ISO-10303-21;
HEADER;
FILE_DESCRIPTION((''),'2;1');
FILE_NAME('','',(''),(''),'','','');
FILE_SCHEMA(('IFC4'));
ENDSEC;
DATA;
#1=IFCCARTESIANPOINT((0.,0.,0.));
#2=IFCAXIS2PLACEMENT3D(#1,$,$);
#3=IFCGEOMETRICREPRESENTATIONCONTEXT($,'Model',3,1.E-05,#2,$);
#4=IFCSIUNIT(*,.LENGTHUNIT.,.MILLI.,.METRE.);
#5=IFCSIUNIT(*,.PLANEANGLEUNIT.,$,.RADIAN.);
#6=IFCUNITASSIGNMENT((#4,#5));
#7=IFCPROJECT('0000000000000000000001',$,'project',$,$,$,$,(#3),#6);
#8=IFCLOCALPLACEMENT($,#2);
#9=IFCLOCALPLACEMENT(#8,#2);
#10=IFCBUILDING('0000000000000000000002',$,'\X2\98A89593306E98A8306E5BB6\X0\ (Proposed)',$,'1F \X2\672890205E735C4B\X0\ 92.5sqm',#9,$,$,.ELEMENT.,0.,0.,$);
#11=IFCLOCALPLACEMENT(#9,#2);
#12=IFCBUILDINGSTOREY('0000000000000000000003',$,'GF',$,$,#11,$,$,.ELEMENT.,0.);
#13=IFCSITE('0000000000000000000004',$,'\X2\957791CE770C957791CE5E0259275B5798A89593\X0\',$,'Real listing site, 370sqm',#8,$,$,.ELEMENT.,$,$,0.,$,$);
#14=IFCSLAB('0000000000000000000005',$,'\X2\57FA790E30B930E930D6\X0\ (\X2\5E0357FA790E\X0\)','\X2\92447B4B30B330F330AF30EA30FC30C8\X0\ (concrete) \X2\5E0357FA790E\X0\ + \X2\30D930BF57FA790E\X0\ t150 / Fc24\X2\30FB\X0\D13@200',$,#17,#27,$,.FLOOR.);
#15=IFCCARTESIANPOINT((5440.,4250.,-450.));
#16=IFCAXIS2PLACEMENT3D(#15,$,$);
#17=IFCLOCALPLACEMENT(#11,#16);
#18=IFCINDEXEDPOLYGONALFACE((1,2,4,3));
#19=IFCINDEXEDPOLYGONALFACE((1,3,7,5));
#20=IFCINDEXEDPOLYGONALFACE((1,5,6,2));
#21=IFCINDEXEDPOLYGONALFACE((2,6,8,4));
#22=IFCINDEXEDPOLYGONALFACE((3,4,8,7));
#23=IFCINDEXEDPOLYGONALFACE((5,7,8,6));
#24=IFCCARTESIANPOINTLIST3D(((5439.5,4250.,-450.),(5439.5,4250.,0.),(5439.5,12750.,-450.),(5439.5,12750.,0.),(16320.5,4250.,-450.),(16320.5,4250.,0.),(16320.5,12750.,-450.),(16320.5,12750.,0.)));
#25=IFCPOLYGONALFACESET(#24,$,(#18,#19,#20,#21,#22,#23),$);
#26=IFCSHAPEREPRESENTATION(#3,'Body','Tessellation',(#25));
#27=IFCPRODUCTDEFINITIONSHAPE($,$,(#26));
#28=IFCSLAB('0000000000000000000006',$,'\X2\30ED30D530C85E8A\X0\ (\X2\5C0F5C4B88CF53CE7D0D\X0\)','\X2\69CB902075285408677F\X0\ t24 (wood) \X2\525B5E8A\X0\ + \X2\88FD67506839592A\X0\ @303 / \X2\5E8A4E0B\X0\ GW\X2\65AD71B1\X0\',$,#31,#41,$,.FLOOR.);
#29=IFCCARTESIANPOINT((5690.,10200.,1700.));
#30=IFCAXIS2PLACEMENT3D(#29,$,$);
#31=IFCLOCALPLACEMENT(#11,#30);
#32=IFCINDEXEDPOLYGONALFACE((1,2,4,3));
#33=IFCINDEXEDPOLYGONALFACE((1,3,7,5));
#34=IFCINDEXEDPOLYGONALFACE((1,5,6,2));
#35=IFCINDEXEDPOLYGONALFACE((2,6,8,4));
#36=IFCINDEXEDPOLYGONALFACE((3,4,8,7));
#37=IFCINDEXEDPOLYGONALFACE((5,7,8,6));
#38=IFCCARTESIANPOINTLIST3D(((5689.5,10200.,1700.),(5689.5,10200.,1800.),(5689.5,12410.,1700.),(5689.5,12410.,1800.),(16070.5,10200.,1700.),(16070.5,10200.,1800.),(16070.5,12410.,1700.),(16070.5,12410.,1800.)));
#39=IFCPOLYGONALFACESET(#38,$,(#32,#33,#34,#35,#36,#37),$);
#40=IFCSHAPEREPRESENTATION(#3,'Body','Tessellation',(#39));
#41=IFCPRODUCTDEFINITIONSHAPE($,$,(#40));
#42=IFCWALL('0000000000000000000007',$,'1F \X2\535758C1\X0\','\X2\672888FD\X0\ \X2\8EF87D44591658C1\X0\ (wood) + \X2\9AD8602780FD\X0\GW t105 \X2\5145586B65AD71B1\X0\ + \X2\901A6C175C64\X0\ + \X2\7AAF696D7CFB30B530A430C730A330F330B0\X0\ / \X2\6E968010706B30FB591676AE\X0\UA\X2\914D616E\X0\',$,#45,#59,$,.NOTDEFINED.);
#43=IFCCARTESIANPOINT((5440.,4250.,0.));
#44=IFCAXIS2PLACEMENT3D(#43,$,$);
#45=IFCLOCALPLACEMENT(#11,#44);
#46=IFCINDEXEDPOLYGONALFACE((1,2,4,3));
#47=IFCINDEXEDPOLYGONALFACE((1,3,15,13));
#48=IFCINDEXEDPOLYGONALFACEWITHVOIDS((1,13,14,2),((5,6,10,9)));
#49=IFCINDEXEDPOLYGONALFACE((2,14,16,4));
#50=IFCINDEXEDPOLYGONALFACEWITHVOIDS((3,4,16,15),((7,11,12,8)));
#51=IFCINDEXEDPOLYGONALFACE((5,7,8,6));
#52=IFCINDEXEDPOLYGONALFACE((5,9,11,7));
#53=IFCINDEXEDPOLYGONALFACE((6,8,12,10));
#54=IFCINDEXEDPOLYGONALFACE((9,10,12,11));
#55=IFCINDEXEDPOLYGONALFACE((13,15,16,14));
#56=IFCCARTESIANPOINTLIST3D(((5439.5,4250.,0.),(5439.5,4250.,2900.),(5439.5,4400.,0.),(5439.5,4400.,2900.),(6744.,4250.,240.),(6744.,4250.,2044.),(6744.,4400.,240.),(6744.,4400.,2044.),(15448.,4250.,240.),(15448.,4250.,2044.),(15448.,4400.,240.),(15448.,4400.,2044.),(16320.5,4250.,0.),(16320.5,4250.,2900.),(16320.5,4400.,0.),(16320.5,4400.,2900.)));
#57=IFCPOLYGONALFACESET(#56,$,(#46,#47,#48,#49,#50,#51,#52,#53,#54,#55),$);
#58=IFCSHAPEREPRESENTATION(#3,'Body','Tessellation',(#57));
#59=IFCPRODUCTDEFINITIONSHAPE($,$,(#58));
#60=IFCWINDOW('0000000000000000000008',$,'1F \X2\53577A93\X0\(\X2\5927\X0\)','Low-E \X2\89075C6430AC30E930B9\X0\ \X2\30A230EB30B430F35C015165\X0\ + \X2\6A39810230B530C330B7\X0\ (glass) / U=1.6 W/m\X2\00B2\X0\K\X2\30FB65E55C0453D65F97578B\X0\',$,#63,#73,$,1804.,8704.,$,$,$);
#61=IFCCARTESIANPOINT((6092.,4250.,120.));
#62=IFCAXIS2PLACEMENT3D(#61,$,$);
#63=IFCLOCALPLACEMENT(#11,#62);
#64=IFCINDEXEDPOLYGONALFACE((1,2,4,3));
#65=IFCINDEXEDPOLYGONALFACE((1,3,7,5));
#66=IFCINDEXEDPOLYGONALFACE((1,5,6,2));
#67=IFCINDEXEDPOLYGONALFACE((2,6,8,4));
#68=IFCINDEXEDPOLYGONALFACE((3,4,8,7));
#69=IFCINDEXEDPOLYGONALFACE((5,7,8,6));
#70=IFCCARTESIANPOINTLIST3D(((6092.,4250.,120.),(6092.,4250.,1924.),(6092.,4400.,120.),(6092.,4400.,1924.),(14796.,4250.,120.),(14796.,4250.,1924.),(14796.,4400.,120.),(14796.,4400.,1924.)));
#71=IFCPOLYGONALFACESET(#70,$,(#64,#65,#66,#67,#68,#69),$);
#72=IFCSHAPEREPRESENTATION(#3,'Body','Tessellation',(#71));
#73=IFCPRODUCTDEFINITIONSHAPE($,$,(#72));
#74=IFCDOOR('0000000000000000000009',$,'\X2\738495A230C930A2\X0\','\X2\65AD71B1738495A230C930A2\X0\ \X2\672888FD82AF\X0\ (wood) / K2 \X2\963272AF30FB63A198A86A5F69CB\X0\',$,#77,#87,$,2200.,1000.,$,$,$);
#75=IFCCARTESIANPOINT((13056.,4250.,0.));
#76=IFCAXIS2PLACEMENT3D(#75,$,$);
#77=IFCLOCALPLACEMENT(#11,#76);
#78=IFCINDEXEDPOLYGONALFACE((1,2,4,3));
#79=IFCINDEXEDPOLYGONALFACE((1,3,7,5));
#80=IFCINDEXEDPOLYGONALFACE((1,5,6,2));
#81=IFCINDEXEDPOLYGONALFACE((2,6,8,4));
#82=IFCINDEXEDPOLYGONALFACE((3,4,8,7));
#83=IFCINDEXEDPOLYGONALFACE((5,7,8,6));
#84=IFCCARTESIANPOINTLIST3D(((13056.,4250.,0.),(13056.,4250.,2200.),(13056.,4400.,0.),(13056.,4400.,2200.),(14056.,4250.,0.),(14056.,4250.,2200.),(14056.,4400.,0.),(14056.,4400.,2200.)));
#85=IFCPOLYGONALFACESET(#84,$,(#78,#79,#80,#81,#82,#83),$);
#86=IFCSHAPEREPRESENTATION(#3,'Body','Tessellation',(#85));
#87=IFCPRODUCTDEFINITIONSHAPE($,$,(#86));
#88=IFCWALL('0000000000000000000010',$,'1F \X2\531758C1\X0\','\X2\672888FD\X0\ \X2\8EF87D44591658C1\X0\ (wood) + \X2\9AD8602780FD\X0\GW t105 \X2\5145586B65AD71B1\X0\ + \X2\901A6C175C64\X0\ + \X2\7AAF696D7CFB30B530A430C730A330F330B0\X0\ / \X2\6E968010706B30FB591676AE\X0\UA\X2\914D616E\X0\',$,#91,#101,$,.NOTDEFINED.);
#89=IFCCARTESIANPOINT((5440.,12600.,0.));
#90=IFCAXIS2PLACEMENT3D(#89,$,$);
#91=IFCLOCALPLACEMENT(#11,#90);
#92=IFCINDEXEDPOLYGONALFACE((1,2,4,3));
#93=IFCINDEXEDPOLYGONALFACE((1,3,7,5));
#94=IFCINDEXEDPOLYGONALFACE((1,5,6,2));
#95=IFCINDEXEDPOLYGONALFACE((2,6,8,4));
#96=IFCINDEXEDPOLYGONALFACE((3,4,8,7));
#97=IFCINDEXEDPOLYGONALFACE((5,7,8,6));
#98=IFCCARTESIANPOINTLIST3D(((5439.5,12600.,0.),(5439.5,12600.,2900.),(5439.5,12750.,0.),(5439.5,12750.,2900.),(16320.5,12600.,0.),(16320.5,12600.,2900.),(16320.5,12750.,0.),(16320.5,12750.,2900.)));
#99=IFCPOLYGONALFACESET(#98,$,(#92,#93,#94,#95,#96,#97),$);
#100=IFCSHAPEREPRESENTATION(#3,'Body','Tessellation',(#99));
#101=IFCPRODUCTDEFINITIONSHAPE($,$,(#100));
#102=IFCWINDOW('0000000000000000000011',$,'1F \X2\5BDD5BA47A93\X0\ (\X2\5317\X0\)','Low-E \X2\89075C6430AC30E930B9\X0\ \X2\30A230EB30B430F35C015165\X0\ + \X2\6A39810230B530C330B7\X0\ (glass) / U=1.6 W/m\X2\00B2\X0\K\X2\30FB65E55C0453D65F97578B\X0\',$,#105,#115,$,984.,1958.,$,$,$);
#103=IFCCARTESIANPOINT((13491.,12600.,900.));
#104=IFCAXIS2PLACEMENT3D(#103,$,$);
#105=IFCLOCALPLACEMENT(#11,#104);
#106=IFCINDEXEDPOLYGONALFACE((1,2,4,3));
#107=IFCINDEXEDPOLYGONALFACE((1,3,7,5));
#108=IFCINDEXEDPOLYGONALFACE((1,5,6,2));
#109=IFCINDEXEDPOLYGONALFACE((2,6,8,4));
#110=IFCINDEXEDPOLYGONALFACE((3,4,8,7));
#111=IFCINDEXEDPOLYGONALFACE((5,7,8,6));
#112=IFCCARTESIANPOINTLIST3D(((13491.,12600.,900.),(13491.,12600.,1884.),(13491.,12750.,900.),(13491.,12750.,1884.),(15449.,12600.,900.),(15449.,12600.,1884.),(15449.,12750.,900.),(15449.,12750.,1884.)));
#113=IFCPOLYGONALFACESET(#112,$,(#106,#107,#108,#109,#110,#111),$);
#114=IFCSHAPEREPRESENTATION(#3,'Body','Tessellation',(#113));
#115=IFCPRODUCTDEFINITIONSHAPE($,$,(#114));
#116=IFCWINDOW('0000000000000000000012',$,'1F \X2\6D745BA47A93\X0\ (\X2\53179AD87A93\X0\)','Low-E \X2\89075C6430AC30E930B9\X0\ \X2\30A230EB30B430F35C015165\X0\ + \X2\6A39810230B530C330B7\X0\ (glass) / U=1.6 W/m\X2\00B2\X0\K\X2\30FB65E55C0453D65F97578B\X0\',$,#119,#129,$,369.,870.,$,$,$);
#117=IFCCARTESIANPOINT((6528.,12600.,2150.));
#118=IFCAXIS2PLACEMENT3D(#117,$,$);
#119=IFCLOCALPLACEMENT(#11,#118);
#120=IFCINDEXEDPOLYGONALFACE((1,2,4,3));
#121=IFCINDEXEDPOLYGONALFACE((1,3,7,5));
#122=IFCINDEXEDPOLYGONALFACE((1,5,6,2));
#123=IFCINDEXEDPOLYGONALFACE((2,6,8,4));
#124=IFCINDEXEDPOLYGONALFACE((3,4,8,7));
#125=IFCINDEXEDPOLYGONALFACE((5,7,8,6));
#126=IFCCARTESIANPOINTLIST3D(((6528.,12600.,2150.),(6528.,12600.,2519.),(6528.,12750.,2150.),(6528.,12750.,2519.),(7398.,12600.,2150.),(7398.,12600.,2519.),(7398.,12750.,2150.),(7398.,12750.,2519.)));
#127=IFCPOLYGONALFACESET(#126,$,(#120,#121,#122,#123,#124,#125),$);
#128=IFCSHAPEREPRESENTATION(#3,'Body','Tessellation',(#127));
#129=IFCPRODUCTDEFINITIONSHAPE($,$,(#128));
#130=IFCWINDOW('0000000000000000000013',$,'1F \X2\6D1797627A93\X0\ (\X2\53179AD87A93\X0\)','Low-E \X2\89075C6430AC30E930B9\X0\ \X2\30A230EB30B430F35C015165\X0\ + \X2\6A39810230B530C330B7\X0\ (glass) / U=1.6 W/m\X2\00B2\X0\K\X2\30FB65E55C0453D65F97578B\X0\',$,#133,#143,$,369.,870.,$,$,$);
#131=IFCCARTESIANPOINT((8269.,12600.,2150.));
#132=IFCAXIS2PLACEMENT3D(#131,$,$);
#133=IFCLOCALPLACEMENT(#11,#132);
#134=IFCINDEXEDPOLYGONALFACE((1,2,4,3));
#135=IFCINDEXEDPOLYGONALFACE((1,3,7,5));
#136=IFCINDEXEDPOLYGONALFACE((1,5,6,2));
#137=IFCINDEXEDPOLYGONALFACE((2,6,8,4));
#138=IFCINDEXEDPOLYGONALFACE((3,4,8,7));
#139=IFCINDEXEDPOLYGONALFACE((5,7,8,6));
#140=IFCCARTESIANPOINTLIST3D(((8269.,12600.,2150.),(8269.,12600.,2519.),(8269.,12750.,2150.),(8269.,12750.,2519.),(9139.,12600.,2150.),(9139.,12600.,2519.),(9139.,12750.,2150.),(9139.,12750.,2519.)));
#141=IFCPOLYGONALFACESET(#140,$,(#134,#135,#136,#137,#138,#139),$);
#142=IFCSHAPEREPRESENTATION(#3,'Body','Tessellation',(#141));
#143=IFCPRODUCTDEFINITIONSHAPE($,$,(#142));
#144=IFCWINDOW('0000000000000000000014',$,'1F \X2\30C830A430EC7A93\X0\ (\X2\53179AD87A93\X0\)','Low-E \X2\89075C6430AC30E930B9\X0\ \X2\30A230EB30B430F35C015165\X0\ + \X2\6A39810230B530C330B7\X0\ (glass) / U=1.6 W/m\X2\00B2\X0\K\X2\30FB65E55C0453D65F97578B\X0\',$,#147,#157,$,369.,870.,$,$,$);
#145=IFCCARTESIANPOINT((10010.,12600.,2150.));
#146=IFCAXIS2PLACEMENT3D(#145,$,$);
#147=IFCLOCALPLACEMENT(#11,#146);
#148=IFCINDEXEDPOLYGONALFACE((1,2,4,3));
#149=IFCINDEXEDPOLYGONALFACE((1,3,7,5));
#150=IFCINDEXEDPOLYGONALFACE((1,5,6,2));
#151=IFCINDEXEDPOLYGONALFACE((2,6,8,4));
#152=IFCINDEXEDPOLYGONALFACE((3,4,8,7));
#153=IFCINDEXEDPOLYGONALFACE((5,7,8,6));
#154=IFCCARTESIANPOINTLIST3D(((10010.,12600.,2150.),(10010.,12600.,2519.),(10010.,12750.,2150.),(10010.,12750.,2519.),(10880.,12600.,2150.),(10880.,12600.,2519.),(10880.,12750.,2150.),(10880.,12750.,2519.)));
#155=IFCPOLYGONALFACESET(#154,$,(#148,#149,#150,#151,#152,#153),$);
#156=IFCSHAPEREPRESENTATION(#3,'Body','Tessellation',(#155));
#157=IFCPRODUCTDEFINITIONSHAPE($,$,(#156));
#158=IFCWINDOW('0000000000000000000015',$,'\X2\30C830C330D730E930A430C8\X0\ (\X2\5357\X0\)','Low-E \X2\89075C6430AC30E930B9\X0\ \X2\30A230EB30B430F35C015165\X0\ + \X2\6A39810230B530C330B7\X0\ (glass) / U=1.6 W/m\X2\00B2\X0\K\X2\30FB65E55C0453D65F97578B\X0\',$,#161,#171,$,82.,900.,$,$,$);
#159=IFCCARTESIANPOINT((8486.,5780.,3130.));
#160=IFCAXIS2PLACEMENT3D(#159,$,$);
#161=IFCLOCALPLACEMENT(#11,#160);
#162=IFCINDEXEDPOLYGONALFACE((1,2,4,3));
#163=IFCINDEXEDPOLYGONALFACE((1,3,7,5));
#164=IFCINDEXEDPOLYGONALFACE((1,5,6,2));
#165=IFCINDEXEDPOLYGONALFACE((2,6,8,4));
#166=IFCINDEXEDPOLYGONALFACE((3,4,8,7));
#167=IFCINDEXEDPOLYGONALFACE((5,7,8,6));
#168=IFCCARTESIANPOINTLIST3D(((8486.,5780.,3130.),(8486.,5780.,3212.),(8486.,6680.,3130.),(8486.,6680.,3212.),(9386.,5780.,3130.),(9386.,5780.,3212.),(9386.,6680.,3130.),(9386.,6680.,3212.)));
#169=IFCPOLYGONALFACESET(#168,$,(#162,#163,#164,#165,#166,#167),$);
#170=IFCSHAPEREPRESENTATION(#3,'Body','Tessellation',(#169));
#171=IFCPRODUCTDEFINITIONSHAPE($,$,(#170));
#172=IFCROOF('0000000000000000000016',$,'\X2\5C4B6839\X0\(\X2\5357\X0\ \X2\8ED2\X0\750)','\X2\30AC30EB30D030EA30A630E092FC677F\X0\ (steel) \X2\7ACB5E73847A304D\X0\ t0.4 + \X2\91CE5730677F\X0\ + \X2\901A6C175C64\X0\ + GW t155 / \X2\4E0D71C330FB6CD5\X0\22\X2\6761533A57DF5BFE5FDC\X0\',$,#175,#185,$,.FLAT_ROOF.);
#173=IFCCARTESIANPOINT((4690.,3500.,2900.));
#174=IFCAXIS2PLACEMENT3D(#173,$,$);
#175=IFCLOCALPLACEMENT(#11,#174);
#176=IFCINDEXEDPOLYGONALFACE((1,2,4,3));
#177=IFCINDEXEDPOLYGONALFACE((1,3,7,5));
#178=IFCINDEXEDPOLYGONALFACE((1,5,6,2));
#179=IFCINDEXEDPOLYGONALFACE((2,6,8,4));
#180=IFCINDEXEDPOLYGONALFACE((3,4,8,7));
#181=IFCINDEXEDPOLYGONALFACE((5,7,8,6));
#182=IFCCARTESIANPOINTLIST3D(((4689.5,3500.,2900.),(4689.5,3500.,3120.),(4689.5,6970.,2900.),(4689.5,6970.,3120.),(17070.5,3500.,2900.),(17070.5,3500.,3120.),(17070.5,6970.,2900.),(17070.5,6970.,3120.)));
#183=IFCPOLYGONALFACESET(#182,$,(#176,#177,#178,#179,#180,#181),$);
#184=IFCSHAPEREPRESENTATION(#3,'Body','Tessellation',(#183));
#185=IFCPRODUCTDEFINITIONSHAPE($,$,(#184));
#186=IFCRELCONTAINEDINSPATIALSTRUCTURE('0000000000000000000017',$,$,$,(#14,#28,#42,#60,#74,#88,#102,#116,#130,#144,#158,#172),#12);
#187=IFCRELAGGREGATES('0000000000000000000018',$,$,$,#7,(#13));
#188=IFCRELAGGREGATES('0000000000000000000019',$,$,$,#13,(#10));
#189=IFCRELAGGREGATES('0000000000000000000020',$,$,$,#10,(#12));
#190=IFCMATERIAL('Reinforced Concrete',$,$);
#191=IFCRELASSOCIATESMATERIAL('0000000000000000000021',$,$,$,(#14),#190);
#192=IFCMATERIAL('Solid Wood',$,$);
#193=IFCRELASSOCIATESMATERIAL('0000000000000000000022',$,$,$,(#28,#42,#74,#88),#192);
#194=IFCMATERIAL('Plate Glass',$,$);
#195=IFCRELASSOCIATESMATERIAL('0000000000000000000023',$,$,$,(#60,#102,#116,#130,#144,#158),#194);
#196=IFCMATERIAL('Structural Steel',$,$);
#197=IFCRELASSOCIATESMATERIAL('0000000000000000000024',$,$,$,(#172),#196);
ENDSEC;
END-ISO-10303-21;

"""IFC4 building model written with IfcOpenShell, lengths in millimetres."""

from ifc_helpers import new_model, si_unit, frame, frame_2d, origin, place, context, project, spatial, rectangle, extrude, material, element, fill, save


model = new_model("IFC4")

# Units and contexts
model_context = context("Model", 3, precision=1e-05, world=origin())
ifc_project = project(units=[si_unit("LENGTHUNIT", "METRE", prefix="MILLI"), si_unit("PLANEANGLEUNIT", "RADIAN")], contexts=[model_context])

# Site, building, storey
site_placement = place(None, origin())
site = spatial("IfcSite", under=ifc_project, at=site_placement, Name="長野県長野市大字風間", ObjectType="Real listing site, 370sqm", CompositionType="ELEMENT", RefElevation=0.0)
building_placement = place(site_placement, origin())
building = spatial("IfcBuilding", under=site, at=building_placement, Name="風間の風の家 (Proposed)", ObjectType="1F 木造平屋 92.5sqm", CompositionType="ELEMENT", ElevationOfRefHeight=0.0, ElevationOfTerrain=0.0)
storey_placement = place(building_placement, origin())
storey = spatial("IfcBuildingStorey", under=building, at=storey_placement, Name="GF", CompositionType="ELEMENT", Elevation=0.0)

# Slabs
ifc_material_1 = material(Name="Reinforced Concrete")
slab_1_placement = place(storey_placement, frame((5440.0, 4250.0, -450.0)))
element("IfcSlab", 1, at=slab_1_placement, inside=storey, material=ifc_material_1, Name="基礎スラブ (布基礎)", Description="鉄筋コンクリート (concrete) 布基礎 + ベタ基礎 t150 / Fc24・D13@200", PredefinedType="FLOOR", context=model_context, shape_type="SweptSolid", body=[
    extrude(rectangle(XDim=10881.0, YDim=8500.0, at=frame_2d((5440.0, 4250.0))), frame((5440.0, 4250.0, -450.0)), (0.0, 0.0, 1.0), 450.0),
])
ifc_material_2 = material(Name="Solid Wood")
slab_2_placement = place(storey_placement, frame((5690.0, 10200.0, 1700.0)))
element("IfcSlab", 2, at=slab_2_placement, inside=storey, material=ifc_material_2, Name="ロフト床 (小屋裏収納)", Description="構造用合板 t24 (wood) 剛床 + 製材根太 @303 / 床下 GW断熱", PredefinedType="FLOOR", context=model_context, shape_type="SweptSolid", body=[
    extrude(rectangle(XDim=10381.0, YDim=2210.0, at=frame_2d((5190.0, 1105.0))), frame((5690.0, 10200.0, 1700.0)), (0.0, 0.0, 1.0), 100.0),
])

# Wall, openings, window, door
wall_1_placement = place(storey_placement, frame((5440.0, 4250.0, 0.0)))
wall_1 = element("IfcWall", 3, at=wall_1_placement, inside=storey, material=ifc_material_2, Name="1F 南壁", Description="木製 軸組外壁 (wood) + 高性能GW t105 充填断熱 + 通気層 + 窯業系サイディング / 準耐火・外皮UA配慮", PredefinedType="NOTDEFINED", context=model_context, shape_type="SweptSolid", body=[
    extrude(rectangle(XDim=10881.0, YDim=150.0, at=frame_2d((5440.0, 75.0))), frame((5440.0, 4250.0, 0.0)), (0.0, 0.0, 1.0), 2900.0),
])
opening_1_placement = place(storey_placement, frame((6092.0, 4250.0, 120.0)))
opening_1 = element("IfcOpeningElement", 4, at=opening_1_placement, cuts=wall_1, PredefinedType="NOTDEFINED", context=model_context, shape_type="SweptSolid", body=[
    extrude(rectangle(XDim=8704.0, YDim=150.0, at=frame_2d((4352.0, 75.0))), frame((6092.0, 4250.0, 120.0)), (0.0, 0.0, 1.0), 1804.0),
])
opening_2_placement = place(storey_placement, frame((13056.0, 4250.0, 0.0)))
opening_2 = element("IfcOpeningElement", 5, at=opening_2_placement, cuts=wall_1, PredefinedType="NOTDEFINED", context=model_context, shape_type="SweptSolid", body=[
    extrude(rectangle(XDim=1000.0, YDim=150.0, at=frame_2d((500.0, 75.0))), frame((13056.0, 4250.0, 0.0)), (0.0, 0.0, 1.0), 2200.0),
])
ifc_material_3 = material(Name="Plate Glass")
window_1_placement = place(storey_placement, frame((6092.0, 4250.0, 120.0)))
window_1 = element("IfcWindow", 6, at=window_1_placement, inside=storey, material=ifc_material_3, Name="1F 南窓(大)", Description="Low-E 複層ガラス アルゴン封入 + 樹脂サッシ (glass) / U=1.6 W/m²K・日射取得型", OverallHeight=1804.0, OverallWidth=8704.0, context=model_context, shape_type="SweptSolid", body=[
    extrude(rectangle(XDim=8704.0, YDim=150.0, at=frame_2d((4352.0, 75.0))), frame((6092.0, 4250.0, 120.0)), (0.0, 0.0, 1.0), 1804.0),
])
fill(opening_1, window_1)
door_1_placement = place(storey_placement, frame((13056.0, 4250.0, 0.0)))
door_1 = element("IfcDoor", 7, at=door_1_placement, inside=storey, material=ifc_material_2, Name="玄関ドア", Description="断熱玄関ドア 木製芯 (wood) / K2 防犯・採風機構", OverallHeight=2200.0, OverallWidth=1000.0, context=model_context, shape_type="SweptSolid", body=[
    extrude(rectangle(XDim=1000.0, YDim=150.0, at=frame_2d((500.0, 75.0))), frame((13056.0, 4250.0, 0.0)), (0.0, 0.0, 1.0), 2200.0),
])
fill(opening_2, door_1)

# Wall, openings, windows
wall_2_placement = place(storey_placement, frame((5440.0, 12600.0, 0.0)))
wall_2 = element("IfcWall", 8, at=wall_2_placement, inside=storey, material=ifc_material_2, Name="1F 北壁", Description="木製 軸組外壁 (wood) + 高性能GW t105 充填断熱 + 通気層 + 窯業系サイディング / 準耐火・外皮UA配慮", PredefinedType="NOTDEFINED", context=model_context, shape_type="SweptSolid", body=[
    extrude(rectangle(XDim=10881.0, YDim=150.0, at=frame_2d((5440.0, 75.0))), frame((5440.0, 12600.0, 0.0)), (0.0, 0.0, 1.0), 2900.0),
])
opening_3_placement = place(storey_placement, frame((13491.0, 12600.0, 900.0)))
opening_3 = element("IfcOpeningElement", 9, at=opening_3_placement, cuts=wall_2, PredefinedType="NOTDEFINED", context=model_context, shape_type="SweptSolid", body=[
    extrude(rectangle(XDim=1958.0, YDim=150.0, at=frame_2d((979.0, 75.0))), frame((13491.0, 12600.0, 900.0)), (0.0, 0.0, 1.0), 984.0),
])
opening_4_placement = place(storey_placement, frame((6528.0, 12600.0, 2150.0)))
opening_4 = element("IfcOpeningElement", 10, at=opening_4_placement, cuts=wall_2, PredefinedType="NOTDEFINED", context=model_context, shape_type="SweptSolid", body=[
    extrude(rectangle(XDim=870.0, YDim=150.0, at=frame_2d((435.0, 75.0))), frame((6528.0, 12600.0, 2150.0)), (0.0, 0.0, 1.0), 369.0),
])
opening_5_placement = place(storey_placement, frame((8269.0, 12600.0, 2150.0)))
opening_5 = element("IfcOpeningElement", 11, at=opening_5_placement, cuts=wall_2, PredefinedType="NOTDEFINED", context=model_context, shape_type="SweptSolid", body=[
    extrude(rectangle(XDim=870.0, YDim=150.0, at=frame_2d((435.0, 75.0))), frame((8269.0, 12600.0, 2150.0)), (0.0, 0.0, 1.0), 369.0),
])
opening_6_placement = place(storey_placement, frame((10010.0, 12600.0, 2150.0)))
opening_6 = element("IfcOpeningElement", 12, at=opening_6_placement, cuts=wall_2, PredefinedType="NOTDEFINED", context=model_context, shape_type="SweptSolid", body=[
    extrude(rectangle(XDim=870.0, YDim=150.0, at=frame_2d((435.0, 75.0))), frame((10010.0, 12600.0, 2150.0)), (0.0, 0.0, 1.0), 369.0),
])
window_2_placement = place(storey_placement, frame((13491.0, 12600.0, 900.0)))
window_2 = element("IfcWindow", 13, at=window_2_placement, inside=storey, material=ifc_material_3, Name="1F 寝室窓 (北)", Description="Low-E 複層ガラス アルゴン封入 + 樹脂サッシ (glass) / U=1.6 W/m²K・日射取得型", OverallHeight=984.0, OverallWidth=1958.0, context=model_context, shape_type="SweptSolid", body=[
    extrude(rectangle(XDim=1958.0, YDim=150.0, at=frame_2d((979.0, 75.0))), frame((13491.0, 12600.0, 900.0)), (0.0, 0.0, 1.0), 984.0),
])
fill(opening_3, window_2)
window_3_placement = place(storey_placement, frame((6528.0, 12600.0, 2150.0)))
window_3 = element("IfcWindow", 14, at=window_3_placement, inside=storey, material=ifc_material_3, Name="1F 浴室窓 (北高窓)", Description="Low-E 複層ガラス アルゴン封入 + 樹脂サッシ (glass) / U=1.6 W/m²K・日射取得型", OverallHeight=369.0, OverallWidth=870.0, context=model_context, shape_type="SweptSolid", body=[
    extrude(rectangle(XDim=870.0, YDim=150.0, at=frame_2d((435.0, 75.0))), frame((6528.0, 12600.0, 2150.0)), (0.0, 0.0, 1.0), 369.0),
])
fill(opening_4, window_3)
window_4_placement = place(storey_placement, frame((8269.0, 12600.0, 2150.0)))
window_4 = element("IfcWindow", 15, at=window_4_placement, inside=storey, material=ifc_material_3, Name="1F 洗面窓 (北高窓)", Description="Low-E 複層ガラス アルゴン封入 + 樹脂サッシ (glass) / U=1.6 W/m²K・日射取得型", OverallHeight=369.0, OverallWidth=870.0, context=model_context, shape_type="SweptSolid", body=[
    extrude(rectangle(XDim=870.0, YDim=150.0, at=frame_2d((435.0, 75.0))), frame((8269.0, 12600.0, 2150.0)), (0.0, 0.0, 1.0), 369.0),
])
fill(opening_5, window_4)
window_5_placement = place(storey_placement, frame((10010.0, 12600.0, 2150.0)))
window_5 = element("IfcWindow", 16, at=window_5_placement, inside=storey, material=ifc_material_3, Name="1F トイレ窓 (北高窓)", Description="Low-E 複層ガラス アルゴン封入 + 樹脂サッシ (glass) / U=1.6 W/m²K・日射取得型", OverallHeight=369.0, OverallWidth=870.0, context=model_context, shape_type="SweptSolid", body=[
    extrude(rectangle(XDim=870.0, YDim=150.0, at=frame_2d((435.0, 75.0))), frame((10010.0, 12600.0, 2150.0)), (0.0, 0.0, 1.0), 369.0),
])
fill(opening_6, window_5)

# Window
window_6_placement = place(storey_placement, frame((8486.0, 5780.0, 3130.0)))
element("IfcWindow", 17, at=window_6_placement, inside=storey, material=ifc_material_3, Name="トップライト (南)", Description="Low-E 複層ガラス アルゴン封入 + 樹脂サッシ (glass) / U=1.6 W/m²K・日射取得型", OverallHeight=82.0, OverallWidth=900.0, context=model_context, shape_type="SweptSolid", body=[
    extrude(rectangle(XDim=900.0, YDim=900.0, at=frame_2d((450.0, 450.0))), frame((8486.0, 5780.0, 3130.0)), (0.0, 0.0, 1.0), 82.0),
])

# Roof
ifc_material_4 = material(Name="Structural Steel")
roof_1_placement = place(storey_placement, frame((4690.0, 3500.0, 2900.0)))
element("IfcRoof", 18, at=roof_1_placement, inside=storey, material=ifc_material_4, Name="屋根(南 軒750)", Description="ガルバリウム鋼板 (steel) 立平葺き t0.4 + 野地板 + 通気層 + GW t155 / 不燃・法22条区域対応", PredefinedType="FLAT_ROOF", context=model_context, shape_type="SweptSolid", body=[
    extrude(rectangle(XDim=12381.0, YDim=3470.0, at=frame_2d((6190.0, 1735.0))), frame((4690.0, 3500.0, 2900.0)), (0.0, 0.0, 1.0), 220.0),
])

save(model, "model.ifc")
